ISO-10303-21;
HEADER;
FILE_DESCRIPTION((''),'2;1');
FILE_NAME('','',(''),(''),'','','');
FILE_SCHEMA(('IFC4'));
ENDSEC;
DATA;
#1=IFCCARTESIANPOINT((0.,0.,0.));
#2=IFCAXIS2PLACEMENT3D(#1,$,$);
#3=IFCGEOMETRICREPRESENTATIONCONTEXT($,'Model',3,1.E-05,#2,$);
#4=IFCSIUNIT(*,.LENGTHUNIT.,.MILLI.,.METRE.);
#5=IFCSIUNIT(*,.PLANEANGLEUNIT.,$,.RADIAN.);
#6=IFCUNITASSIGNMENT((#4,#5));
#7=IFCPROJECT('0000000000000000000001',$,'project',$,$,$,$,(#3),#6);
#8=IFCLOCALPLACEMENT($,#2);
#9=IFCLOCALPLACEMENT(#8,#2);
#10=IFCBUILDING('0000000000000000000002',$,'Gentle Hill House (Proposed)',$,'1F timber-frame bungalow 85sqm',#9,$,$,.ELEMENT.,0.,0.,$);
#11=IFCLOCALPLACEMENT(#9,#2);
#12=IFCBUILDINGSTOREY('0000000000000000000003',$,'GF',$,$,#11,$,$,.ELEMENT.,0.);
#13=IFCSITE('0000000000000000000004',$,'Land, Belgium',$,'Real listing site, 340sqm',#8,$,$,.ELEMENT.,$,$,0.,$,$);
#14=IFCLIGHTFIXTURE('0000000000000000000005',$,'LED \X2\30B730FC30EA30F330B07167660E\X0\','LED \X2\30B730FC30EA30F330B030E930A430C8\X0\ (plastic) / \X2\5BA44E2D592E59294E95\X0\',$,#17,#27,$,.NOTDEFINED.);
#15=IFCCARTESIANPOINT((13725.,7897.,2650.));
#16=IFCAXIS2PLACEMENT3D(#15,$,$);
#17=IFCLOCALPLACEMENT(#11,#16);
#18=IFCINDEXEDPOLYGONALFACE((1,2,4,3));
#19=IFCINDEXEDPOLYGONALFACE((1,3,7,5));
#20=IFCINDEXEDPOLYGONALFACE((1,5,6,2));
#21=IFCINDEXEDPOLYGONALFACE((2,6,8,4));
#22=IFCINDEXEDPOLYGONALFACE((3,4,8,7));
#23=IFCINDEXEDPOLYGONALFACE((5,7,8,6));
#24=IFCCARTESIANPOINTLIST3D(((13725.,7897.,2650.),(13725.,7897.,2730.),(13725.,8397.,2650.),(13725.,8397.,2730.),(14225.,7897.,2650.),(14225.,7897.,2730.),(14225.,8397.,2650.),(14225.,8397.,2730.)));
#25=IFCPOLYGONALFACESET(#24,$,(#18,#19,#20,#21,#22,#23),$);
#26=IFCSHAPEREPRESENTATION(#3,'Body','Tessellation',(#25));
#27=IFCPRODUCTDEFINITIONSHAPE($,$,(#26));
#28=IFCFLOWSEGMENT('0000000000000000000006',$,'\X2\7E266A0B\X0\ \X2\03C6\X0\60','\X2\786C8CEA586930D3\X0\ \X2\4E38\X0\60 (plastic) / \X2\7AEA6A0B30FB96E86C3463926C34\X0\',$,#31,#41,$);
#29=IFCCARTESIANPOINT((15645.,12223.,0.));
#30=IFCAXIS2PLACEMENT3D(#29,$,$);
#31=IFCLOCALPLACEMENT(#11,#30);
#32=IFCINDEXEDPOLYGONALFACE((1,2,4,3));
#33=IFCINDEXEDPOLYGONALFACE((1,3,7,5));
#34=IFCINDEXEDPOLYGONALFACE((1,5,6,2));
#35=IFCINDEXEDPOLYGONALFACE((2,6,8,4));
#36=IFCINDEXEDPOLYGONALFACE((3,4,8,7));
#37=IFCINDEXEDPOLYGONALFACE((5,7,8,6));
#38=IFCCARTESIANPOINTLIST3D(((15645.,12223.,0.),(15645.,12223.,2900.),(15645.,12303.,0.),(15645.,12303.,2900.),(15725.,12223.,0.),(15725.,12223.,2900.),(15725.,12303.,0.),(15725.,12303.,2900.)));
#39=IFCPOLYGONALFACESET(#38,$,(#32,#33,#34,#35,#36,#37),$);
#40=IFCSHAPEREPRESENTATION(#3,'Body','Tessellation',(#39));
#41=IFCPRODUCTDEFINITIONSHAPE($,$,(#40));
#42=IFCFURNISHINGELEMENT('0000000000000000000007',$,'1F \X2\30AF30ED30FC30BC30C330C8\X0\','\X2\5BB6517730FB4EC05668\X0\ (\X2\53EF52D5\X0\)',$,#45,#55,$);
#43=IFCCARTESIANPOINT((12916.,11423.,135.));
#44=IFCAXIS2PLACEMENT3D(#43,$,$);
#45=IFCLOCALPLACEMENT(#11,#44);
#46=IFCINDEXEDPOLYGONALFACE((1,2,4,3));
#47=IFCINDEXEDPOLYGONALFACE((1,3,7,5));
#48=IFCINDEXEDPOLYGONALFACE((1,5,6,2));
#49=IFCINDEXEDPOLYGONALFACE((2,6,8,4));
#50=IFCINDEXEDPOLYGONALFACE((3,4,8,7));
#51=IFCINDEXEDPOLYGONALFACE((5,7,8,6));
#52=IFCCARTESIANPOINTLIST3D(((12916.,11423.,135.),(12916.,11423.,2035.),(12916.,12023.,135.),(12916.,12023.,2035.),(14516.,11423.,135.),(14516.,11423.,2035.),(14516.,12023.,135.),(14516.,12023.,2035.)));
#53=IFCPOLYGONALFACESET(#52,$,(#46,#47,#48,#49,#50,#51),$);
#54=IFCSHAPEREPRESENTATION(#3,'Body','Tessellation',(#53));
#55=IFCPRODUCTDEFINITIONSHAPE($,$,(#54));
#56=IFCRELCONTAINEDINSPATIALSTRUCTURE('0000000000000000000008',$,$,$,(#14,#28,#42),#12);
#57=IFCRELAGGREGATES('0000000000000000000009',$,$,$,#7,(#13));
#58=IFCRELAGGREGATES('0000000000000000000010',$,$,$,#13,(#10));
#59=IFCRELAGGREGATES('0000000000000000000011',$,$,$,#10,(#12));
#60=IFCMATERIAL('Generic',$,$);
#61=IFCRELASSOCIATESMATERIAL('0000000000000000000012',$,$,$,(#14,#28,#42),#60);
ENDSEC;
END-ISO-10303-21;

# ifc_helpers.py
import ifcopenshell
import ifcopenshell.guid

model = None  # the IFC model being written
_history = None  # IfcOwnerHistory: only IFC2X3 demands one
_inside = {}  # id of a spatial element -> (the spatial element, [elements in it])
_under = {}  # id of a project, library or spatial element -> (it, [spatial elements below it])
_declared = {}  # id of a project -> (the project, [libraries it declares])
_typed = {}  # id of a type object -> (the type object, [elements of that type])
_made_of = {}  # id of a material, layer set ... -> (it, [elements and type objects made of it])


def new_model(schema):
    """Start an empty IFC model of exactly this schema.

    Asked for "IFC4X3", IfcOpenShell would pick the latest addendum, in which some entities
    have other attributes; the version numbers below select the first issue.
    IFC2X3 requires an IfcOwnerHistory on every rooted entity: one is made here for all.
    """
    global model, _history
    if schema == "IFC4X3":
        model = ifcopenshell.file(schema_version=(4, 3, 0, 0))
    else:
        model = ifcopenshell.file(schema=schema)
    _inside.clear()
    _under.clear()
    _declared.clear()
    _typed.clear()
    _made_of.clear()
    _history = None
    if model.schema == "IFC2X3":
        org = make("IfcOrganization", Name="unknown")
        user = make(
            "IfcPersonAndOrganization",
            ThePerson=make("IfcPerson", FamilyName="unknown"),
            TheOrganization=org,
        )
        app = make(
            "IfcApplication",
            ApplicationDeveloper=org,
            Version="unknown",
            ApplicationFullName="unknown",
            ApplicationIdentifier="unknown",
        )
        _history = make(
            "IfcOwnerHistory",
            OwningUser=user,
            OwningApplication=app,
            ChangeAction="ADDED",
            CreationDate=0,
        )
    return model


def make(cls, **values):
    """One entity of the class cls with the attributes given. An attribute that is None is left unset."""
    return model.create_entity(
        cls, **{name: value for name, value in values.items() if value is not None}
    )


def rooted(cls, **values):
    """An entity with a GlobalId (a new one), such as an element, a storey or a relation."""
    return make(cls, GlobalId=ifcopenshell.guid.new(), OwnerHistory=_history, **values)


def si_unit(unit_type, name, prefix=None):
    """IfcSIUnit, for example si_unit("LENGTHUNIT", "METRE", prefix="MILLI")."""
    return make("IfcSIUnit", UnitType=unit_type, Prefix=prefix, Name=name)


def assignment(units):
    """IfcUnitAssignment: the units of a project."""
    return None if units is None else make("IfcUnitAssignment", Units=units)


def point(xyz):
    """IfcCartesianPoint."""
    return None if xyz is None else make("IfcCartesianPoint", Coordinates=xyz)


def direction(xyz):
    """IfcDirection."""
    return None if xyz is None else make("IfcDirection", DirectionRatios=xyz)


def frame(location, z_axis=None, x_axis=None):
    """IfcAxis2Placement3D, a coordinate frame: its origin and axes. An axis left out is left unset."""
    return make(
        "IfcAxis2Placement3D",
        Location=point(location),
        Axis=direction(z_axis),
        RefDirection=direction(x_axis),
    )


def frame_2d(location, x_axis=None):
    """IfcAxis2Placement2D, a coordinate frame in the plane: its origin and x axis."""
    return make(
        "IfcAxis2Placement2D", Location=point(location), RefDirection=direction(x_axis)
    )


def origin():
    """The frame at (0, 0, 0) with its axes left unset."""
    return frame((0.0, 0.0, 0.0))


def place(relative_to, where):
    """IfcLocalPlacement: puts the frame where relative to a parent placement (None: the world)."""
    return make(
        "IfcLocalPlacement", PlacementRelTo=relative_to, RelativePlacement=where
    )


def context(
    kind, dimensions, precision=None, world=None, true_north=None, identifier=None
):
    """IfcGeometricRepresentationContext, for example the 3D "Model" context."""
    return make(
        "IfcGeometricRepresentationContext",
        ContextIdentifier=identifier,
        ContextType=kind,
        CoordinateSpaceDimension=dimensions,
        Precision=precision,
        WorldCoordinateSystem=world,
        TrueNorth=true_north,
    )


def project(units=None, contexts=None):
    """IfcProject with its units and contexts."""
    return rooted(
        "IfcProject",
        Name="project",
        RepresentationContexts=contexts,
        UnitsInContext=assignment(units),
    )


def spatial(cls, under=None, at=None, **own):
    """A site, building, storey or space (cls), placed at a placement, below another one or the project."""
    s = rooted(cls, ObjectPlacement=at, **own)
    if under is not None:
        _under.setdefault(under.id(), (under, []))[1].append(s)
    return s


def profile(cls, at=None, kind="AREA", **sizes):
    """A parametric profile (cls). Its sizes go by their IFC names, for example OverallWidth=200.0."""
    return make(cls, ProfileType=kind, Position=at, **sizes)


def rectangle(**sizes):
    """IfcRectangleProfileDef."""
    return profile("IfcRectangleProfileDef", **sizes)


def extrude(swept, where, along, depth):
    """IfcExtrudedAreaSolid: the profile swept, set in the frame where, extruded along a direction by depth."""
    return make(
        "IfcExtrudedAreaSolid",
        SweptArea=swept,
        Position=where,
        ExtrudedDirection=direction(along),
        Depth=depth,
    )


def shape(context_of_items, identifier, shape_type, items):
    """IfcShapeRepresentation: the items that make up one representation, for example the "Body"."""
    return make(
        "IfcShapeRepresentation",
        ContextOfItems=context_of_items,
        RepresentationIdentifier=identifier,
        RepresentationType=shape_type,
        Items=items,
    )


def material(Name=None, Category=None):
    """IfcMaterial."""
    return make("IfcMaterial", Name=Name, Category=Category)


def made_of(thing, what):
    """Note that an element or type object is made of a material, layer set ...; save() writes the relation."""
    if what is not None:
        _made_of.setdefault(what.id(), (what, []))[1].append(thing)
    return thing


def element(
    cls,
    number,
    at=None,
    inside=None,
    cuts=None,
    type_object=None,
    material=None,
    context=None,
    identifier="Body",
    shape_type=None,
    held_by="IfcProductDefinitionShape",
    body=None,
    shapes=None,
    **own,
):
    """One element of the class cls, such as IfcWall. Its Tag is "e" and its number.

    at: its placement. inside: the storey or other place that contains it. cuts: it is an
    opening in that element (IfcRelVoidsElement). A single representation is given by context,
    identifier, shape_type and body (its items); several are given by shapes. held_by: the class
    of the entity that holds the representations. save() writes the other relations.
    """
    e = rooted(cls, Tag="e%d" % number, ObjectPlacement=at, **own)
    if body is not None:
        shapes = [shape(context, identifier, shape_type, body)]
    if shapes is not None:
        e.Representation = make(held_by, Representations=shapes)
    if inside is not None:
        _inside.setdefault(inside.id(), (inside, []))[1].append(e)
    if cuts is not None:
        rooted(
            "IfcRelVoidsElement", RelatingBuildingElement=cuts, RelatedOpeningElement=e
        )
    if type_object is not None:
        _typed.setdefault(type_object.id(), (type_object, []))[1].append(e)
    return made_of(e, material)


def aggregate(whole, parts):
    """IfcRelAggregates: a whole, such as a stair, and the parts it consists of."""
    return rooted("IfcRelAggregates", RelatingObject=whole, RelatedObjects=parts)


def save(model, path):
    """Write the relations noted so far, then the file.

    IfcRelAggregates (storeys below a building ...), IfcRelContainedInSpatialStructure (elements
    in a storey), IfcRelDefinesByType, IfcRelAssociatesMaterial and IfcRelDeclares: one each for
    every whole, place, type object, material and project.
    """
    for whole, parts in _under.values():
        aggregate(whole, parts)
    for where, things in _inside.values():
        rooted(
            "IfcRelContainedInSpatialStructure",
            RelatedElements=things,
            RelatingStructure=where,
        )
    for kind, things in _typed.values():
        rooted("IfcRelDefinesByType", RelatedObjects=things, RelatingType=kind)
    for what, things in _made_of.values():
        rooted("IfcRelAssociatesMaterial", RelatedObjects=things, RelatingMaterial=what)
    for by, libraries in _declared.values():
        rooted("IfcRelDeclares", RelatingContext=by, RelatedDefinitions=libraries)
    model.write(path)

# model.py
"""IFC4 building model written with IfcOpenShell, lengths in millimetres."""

from ifc_helpers import new_model, si_unit, frame, frame_2d, origin, place, context, project, spatial, rectangle, extrude, material, element, save


model = new_model("IFC4")

# Units and contexts
model_context = context("Model", 3, precision=1e-05, world=origin())
ifc_project = project(units=[si_unit("LENGTHUNIT", "METRE", prefix="MILLI"), si_unit("PLANEANGLEUNIT", "RADIAN")], contexts=[model_context])

# Site, building, storey
site_placement = place(None, origin())
site = spatial("IfcSite", under=ifc_project, at=site_placement, Name="Land, Belgium", ObjectType="Real listing site, 340sqm", CompositionType="ELEMENT", RefElevation=0.0)
building_placement = place(site_placement, origin())
building = spatial("IfcBuilding", under=site, at=building_placement, Name="Gentle Hill House (Proposed)", ObjectType="1F timber-frame bungalow 85sqm", CompositionType="ELEMENT", ElevationOfRefHeight=0.0, ElevationOfTerrain=0.0)
storey_placement = place(building_placement, origin())
storey = spatial("IfcBuildingStorey", under=building, at=storey_placement, Name="GF", CompositionType="ELEMENT", Elevation=0.0)

# Shared definitions
ifc_material_1 = material(Name="Generic")

# Light fixture
light_fixture_1_placement = place(storey_placement, frame((13725.0, 7897.0, 2650.0)))
element("IfcLightFixture", 1, at=light_fixture_1_placement, inside=storey, material=ifc_material_1, Name="LED シーリング照明", Description="LED シーリングライト (plastic) / 室中央天井", PredefinedType="NOTDEFINED", context=model_context, shape_type="SweptSolid", body=[
    extrude(rectangle(XDim=500.0, YDim=500.0, at=frame_2d((250.0, 250.0))), frame((13725.0, 7897.0, 2650.0)), (0.0, 0.0, 1.0), 80.0),
])

# Flow segment
flow_segment_placement = place(storey_placement, frame((15645.0, 12223.0, 0.0)))
element("IfcFlowSegment", 2, at=flow_segment_placement, inside=storey, material=ifc_material_1, Name="縦樋 φ60", Description="硬質塩ビ 丸60 (plastic) / 竪樋・雨水排水", context=model_context, shape_type="SweptSolid", body=[
    extrude(rectangle(XDim=80.0, YDim=80.0, at=frame_2d((40.0, 40.0))), frame((15645.0, 12223.0, 0.0)), (0.0, 0.0, 1.0), 2900.0),
])

# Furnishing element
furnishing_placement = place(storey_placement, frame((12916.0, 11423.0, 135.0)))
element("IfcFurnishingElement", 3, at=furnishing_placement, inside=storey, material=ifc_material_1, Name="1F クローゼット", Description="家具・什器 (可動)", context=model_context, shape_type="SweptSolid", body=[
    extrude(rectangle(XDim=1600.0, YDim=600.0, at=frame_2d((800.0, 300.0))), frame((12916.0, 11423.0, 135.0)), (0.0, 0.0, 1.0), 1900.0),
])

save(model, "model.ifc")
